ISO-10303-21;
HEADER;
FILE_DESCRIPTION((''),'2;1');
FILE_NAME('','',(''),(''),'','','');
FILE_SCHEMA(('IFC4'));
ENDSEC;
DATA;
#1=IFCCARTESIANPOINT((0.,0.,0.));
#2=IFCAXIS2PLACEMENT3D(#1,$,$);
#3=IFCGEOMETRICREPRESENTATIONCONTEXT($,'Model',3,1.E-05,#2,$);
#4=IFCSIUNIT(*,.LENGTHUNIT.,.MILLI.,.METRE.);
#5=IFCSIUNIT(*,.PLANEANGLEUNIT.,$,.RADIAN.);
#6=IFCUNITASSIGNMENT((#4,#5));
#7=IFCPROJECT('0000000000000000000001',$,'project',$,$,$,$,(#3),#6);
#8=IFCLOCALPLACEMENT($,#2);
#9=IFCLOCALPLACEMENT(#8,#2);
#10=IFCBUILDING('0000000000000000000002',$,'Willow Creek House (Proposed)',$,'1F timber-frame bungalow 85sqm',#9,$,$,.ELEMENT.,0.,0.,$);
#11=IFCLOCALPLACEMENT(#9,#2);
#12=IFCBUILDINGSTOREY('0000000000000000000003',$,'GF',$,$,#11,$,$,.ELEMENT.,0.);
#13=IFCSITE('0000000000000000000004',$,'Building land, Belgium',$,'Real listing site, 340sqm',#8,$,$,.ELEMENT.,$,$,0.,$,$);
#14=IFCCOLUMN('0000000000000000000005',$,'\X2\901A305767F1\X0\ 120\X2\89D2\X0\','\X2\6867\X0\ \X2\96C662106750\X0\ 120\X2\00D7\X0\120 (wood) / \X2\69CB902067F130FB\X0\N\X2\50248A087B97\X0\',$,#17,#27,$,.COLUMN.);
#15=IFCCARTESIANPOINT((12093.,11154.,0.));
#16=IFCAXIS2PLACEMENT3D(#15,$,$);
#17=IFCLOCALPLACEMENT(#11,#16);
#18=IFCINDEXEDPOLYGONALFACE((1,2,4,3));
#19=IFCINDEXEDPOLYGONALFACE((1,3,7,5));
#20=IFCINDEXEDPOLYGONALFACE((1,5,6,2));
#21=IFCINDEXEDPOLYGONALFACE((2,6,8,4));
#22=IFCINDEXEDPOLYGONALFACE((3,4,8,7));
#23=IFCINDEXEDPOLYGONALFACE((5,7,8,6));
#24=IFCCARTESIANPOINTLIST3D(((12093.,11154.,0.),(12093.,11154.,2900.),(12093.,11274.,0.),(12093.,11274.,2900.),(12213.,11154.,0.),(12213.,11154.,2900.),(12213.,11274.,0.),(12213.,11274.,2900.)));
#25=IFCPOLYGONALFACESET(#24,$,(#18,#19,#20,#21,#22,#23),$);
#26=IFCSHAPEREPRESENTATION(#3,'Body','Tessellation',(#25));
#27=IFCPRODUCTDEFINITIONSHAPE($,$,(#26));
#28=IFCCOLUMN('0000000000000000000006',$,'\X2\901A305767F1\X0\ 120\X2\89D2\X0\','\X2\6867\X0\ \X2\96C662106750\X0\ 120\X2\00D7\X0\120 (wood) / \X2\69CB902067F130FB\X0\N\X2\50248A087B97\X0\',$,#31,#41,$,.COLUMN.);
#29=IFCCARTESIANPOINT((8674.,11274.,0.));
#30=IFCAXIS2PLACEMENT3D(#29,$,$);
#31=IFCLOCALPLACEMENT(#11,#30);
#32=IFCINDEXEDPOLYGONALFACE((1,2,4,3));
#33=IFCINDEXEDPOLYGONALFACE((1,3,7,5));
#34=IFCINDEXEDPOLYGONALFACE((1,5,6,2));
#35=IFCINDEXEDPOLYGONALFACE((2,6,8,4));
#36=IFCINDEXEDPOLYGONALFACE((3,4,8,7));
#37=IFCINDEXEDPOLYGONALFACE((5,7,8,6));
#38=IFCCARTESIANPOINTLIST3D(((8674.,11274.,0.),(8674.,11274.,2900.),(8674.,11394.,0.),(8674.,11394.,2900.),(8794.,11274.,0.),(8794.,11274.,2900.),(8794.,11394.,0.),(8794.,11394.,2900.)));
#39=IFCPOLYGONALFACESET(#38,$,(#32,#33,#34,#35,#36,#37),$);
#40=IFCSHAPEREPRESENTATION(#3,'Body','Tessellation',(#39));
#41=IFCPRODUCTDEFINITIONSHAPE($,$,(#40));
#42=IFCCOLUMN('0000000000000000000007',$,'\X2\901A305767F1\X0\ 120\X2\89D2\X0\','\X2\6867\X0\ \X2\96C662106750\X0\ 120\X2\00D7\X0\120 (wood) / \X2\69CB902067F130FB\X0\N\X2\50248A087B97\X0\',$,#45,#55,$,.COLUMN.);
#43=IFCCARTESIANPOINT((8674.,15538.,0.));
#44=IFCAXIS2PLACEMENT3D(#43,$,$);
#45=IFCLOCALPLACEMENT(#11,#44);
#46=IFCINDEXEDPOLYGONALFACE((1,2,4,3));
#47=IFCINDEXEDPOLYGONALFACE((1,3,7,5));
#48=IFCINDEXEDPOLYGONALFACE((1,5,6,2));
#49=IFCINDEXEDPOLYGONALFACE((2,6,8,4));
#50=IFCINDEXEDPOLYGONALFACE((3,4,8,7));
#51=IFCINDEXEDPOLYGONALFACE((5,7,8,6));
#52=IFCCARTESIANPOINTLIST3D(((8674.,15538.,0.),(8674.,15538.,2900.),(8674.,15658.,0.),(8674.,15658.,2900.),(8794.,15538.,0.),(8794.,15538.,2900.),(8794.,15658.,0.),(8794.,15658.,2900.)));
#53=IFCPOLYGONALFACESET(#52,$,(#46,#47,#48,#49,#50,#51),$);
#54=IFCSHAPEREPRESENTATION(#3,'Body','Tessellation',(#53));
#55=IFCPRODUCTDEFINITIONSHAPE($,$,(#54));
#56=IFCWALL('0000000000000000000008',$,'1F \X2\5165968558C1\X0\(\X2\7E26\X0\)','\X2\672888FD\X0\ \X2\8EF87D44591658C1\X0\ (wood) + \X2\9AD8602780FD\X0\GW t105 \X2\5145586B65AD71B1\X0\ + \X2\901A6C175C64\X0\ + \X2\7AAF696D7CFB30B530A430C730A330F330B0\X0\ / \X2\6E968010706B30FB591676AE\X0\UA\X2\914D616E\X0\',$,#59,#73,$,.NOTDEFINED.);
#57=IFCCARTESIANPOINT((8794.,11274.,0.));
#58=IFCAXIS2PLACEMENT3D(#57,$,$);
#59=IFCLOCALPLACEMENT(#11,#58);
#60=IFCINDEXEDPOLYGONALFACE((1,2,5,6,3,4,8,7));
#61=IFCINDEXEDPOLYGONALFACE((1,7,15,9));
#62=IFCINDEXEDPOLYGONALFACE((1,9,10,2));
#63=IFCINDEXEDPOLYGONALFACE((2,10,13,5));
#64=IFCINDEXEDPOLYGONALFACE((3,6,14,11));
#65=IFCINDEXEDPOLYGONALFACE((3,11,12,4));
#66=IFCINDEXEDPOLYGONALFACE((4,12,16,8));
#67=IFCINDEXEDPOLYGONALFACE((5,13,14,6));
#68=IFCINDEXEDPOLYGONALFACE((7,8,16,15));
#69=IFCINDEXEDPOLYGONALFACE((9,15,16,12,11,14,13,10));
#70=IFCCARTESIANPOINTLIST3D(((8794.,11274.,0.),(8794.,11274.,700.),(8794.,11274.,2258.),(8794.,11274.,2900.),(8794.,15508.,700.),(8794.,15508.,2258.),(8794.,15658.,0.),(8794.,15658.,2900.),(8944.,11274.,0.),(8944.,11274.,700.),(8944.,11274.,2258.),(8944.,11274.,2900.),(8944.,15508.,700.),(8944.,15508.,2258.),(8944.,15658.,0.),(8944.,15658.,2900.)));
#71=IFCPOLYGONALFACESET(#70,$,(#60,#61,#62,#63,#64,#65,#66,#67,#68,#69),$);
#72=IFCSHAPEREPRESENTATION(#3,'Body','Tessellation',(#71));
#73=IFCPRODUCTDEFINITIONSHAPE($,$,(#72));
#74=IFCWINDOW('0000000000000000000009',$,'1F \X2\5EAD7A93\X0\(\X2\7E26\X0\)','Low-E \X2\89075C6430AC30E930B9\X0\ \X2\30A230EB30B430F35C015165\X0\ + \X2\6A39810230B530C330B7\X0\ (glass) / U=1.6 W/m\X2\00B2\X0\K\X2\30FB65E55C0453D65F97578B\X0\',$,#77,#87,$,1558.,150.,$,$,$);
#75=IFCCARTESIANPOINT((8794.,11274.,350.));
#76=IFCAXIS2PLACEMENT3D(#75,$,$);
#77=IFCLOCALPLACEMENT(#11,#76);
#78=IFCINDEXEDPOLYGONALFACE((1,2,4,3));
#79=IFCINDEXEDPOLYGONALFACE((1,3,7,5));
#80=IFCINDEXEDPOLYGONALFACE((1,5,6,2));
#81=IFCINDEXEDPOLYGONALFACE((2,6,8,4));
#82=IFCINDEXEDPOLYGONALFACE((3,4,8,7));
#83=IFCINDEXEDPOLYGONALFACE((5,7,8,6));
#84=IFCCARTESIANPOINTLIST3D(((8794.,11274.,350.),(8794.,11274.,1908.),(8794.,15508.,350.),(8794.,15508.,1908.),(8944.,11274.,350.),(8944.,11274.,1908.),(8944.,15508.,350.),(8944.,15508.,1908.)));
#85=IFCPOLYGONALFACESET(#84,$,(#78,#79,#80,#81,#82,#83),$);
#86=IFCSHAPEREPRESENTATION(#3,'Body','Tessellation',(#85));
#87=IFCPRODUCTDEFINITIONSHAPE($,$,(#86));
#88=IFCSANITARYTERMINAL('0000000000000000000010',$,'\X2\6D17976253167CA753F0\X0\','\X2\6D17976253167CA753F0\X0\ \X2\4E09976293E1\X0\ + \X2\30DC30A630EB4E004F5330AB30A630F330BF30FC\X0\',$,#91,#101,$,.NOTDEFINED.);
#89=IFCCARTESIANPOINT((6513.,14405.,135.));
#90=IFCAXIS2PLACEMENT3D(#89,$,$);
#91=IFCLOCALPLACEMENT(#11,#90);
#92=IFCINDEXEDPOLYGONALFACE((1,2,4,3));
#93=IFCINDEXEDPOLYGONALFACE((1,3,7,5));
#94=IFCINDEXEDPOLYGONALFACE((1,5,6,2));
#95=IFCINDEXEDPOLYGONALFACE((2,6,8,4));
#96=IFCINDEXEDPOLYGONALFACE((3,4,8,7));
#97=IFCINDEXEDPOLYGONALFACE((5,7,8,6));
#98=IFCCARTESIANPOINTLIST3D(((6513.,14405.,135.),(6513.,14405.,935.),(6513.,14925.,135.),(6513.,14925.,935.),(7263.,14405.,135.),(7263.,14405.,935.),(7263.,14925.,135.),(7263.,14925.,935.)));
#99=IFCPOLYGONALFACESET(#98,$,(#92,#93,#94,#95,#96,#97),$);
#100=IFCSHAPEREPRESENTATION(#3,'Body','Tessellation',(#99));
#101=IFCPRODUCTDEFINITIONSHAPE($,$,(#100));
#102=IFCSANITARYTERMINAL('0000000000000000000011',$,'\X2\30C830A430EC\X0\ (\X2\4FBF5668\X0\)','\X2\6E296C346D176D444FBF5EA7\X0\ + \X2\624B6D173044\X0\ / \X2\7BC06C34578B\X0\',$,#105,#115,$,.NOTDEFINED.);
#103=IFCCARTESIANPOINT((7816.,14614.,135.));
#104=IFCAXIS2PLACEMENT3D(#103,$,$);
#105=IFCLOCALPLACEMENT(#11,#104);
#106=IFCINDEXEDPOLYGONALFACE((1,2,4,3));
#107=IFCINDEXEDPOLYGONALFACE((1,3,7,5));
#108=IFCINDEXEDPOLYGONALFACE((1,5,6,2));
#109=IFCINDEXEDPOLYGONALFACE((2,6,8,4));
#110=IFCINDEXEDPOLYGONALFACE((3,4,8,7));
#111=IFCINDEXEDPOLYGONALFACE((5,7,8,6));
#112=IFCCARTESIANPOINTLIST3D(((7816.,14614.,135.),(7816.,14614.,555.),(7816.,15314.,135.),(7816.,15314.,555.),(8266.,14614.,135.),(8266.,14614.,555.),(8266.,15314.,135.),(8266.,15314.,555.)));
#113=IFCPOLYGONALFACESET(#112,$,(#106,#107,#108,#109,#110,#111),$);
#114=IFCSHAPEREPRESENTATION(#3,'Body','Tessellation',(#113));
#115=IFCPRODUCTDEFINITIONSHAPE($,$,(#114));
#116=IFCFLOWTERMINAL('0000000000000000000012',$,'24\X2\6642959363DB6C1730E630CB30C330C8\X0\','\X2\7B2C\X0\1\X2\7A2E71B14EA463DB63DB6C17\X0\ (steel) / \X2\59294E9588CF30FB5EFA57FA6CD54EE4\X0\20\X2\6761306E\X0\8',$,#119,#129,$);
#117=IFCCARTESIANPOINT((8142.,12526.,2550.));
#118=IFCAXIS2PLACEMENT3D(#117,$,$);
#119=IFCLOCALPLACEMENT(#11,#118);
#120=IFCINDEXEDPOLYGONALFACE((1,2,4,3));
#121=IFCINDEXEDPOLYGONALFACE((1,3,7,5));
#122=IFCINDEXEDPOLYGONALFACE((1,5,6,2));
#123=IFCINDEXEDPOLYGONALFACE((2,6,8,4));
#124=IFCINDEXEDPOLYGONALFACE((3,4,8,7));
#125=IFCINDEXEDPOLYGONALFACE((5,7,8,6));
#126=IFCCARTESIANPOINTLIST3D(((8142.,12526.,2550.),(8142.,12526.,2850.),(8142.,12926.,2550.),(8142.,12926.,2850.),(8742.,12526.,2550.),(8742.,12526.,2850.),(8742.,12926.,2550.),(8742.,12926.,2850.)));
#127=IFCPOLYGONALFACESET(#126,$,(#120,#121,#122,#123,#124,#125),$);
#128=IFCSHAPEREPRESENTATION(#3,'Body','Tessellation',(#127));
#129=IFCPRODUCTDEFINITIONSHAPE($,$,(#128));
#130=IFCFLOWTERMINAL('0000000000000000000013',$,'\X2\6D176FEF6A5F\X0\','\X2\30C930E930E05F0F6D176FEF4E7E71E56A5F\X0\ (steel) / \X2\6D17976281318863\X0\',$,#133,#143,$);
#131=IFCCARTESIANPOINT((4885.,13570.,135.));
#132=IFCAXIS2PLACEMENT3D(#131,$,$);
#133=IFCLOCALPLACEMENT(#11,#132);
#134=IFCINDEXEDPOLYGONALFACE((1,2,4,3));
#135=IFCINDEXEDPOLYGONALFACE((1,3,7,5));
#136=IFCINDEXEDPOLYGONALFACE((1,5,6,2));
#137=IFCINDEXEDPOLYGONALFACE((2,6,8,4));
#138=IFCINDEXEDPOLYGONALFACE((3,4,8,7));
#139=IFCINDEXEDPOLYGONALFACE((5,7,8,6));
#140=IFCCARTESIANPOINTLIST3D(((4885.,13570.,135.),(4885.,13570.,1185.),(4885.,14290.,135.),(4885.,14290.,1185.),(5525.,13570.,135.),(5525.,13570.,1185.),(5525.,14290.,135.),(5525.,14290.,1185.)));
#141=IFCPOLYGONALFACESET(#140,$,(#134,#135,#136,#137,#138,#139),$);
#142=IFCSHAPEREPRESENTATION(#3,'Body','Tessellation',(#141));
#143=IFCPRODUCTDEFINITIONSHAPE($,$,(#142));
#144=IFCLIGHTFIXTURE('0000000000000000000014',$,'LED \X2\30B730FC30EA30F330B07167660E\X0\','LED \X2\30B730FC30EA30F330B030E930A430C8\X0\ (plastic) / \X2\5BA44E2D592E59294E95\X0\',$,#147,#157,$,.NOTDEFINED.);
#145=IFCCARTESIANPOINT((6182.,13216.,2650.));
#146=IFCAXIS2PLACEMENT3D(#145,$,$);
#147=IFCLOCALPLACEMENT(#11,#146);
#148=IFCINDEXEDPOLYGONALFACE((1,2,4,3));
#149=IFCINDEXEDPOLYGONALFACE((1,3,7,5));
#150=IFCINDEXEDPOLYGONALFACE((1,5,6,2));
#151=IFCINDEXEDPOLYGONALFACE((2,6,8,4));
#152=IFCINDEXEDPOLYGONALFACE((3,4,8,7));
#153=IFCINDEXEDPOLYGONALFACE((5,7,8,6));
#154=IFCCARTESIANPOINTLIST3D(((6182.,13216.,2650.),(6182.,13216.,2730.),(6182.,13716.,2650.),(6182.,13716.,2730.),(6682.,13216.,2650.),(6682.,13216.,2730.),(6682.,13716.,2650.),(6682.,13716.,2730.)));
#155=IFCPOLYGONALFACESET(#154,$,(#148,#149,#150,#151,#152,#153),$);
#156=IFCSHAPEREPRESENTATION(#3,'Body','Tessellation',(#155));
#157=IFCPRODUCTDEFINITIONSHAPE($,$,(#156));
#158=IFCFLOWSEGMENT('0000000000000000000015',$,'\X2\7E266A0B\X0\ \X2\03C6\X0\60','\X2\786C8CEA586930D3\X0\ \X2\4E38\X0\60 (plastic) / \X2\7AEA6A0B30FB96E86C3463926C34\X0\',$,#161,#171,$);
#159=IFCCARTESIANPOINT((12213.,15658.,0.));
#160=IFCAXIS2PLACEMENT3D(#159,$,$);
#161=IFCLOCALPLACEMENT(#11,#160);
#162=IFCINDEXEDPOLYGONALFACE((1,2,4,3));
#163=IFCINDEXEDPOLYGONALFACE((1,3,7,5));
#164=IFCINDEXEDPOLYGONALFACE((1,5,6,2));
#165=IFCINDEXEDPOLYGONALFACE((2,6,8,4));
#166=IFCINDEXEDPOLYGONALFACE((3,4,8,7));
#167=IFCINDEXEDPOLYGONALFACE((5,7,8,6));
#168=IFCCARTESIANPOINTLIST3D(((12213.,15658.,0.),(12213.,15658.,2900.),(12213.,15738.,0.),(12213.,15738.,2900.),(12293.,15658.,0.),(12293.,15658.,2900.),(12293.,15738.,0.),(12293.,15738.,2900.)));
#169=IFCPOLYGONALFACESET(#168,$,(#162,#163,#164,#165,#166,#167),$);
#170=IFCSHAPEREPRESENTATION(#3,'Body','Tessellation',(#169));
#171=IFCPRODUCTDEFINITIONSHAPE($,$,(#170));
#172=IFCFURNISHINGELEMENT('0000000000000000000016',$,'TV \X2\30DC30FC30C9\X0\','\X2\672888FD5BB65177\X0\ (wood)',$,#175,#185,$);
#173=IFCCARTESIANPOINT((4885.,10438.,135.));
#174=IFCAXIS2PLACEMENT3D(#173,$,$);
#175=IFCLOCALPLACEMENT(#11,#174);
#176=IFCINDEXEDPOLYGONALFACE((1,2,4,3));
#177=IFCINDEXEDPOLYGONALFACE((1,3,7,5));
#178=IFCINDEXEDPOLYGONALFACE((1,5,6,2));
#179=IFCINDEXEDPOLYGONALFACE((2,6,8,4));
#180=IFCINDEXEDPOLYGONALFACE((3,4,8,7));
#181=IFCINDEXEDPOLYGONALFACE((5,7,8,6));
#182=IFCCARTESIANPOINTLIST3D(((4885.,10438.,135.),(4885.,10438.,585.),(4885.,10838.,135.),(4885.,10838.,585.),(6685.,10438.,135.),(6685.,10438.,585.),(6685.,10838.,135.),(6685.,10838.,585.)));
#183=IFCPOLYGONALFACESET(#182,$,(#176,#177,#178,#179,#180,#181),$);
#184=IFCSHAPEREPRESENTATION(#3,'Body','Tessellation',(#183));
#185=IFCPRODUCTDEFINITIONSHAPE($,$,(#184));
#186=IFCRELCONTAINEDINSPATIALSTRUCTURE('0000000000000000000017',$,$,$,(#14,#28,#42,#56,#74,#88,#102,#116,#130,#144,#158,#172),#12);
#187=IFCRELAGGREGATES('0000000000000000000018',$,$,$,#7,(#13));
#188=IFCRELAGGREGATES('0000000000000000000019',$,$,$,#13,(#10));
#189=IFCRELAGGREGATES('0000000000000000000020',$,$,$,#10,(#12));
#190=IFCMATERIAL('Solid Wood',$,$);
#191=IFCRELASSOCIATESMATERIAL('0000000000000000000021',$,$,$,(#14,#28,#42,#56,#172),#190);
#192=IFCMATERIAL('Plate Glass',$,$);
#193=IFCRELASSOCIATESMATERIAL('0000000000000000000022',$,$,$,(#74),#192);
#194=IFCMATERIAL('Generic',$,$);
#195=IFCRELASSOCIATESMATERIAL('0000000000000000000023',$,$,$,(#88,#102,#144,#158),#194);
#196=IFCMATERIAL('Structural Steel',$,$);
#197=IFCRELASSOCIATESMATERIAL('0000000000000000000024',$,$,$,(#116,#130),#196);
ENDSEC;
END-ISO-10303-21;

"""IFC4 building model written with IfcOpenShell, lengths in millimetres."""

from ifc_helpers import new_model, si_unit, frame, frame_2d, origin, place, context, project, spatial, rectangle, extrude, material, element, fill, save


model = new_model("IFC4")

# Units and contexts
model_context = context("Model", 3, precision=1e-05, world=origin())
ifc_project = project(units=[si_unit("LENGTHUNIT", "METRE", prefix="MILLI"), si_unit("PLANEANGLEUNIT", "RADIAN")], contexts=[model_context])

# Site, building, storey
site_placement = place(None, origin())
site = spatial("IfcSite", under=ifc_project, at=site_placement, Name="Building land, Belgium", ObjectType="Real listing site, 340sqm", CompositionType="ELEMENT", RefElevation=0.0)
building_placement = place(site_placement, origin())
building = spatial("IfcBuilding", under=site, at=building_placement, Name="Willow Creek House (Proposed)", ObjectType="1F timber-frame bungalow 85sqm", CompositionType="ELEMENT", ElevationOfRefHeight=0.0, ElevationOfTerrain=0.0)
storey_placement = place(building_placement, origin())
storey = spatial("IfcBuildingStorey", under=building, at=storey_placement, Name="GF", CompositionType="ELEMENT", Elevation=0.0)

# Columns
ifc_material_1 = material(Name="Solid Wood")
column_1_placement = place(storey_placement, frame((12093.0, 11154.0, 0.0)))
element("IfcColumn", 1, at=column_1_placement, inside=storey, material=ifc_material_1, Name="通し柱 120角", Description="桧 集成材 120×120 (wood) / 構造柱・N値計算", PredefinedType="COLUMN", context=model_context, shape_type="SweptSolid", body=[
    extrude(rectangle(XDim=120.0, YDim=120.0, at=frame_2d((60.0, 60.0))), frame((12093.0, 11154.0, 0.0)), (0.0, 0.0, 1.0), 2900.0),
])
column_2_placement = place(storey_placement, frame((8674.0, 11274.0, 0.0)))
element("IfcColumn", 2, at=column_2_placement, inside=storey, material=ifc_material_1, Name="通し柱 120角", Description="桧 集成材 120×120 (wood) / 構造柱・N値計算", PredefinedType="COLUMN", context=model_context, shape_type="SweptSolid", body=[
    extrude(rectangle(XDim=120.0, YDim=120.0, at=frame_2d((60.0, 60.0))), frame((8674.0, 11274.0, 0.0)), (0.0, 0.0, 1.0), 2900.0),
])
column_3_placement = place(storey_placement, frame((8674.0, 15538.0, 0.0)))
element("IfcColumn", 3, at=column_3_placement, inside=storey, material=ifc_material_1, Name="通し柱 120角", Description="桧 集成材 120×120 (wood) / 構造柱・N値計算", PredefinedType="COLUMN", context=model_context, shape_type="SweptSolid", body=[
    extrude(rectangle(XDim=120.0, YDim=120.0, at=frame_2d((60.0, 60.0))), frame((8674.0, 15538.0, 0.0)), (0.0, 0.0, 1.0), 2900.0),
])

# Wall, opening, window
wall_1_placement = place(storey_placement, frame((8794.0, 11274.0, 0.0)))
wall_1 = element("IfcWall", 4, at=wall_1_placement, inside=storey, material=ifc_material_1, Name="1F 入隅壁(縦)", Description="木製 軸組外壁 (wood) + 高性能GW t105 充填断熱 + 通気層 + 窯業系サイディング / 準耐火・外皮UA配慮", PredefinedType="NOTDEFINED", context=model_context, shape_type="SweptSolid", body=[
    extrude(rectangle(XDim=150.0, YDim=4384.0, at=frame_2d((75.0, 2192.0))), frame((8794.0, 11274.0, 0.0)), (0.0, 0.0, 1.0), 2900.0),
])
opening_placement = place(storey_placement, frame((8794.0, 11274.0, 350.0)))
opening = element("IfcOpeningElement", 5, at=opening_placement, cuts=wall_1, PredefinedType="NOTDEFINED", context=model_context, shape_type="SweptSolid", body=[
    extrude(rectangle(XDim=150.0, YDim=4234.0, at=frame_2d((75.0, 2117.0))), frame((8794.0, 11274.0, 350.0)), (0.0, 0.0, 1.0), 1558.0),
])
ifc_material_2 = material(Name="Plate Glass")
window_placement = place(storey_placement, frame((8794.0, 11274.0, 350.0)))
window = element("IfcWindow", 6, at=window_placement, inside=storey, material=ifc_material_2, Name="1F 庭窓(縦)", Description="Low-E 複層ガラス アルゴン封入 + 樹脂サッシ (glass) / U=1.6 W/m²K・日射取得型", OverallHeight=1558.0, OverallWidth=150.0, context=model_context, shape_type="SweptSolid", body=[
    extrude(rectangle(XDim=150.0, YDim=4234.0, at=frame_2d((75.0, 2117.0))), frame((8794.0, 11274.0, 350.0)), (0.0, 0.0, 1.0), 1558.0),
])
fill(opening, window)

# Sanitary terminals
ifc_material_3 = material(Name="Generic")
sanitary_terminal_1_placement = place(storey_placement, frame((6513.0, 14405.0, 135.0)))
element("IfcSanitaryTerminal", 7, at=sanitary_terminal_1_placement, inside=storey, material=ifc_material_3, Name="洗面化粧台", Description="洗面化粧台 三面鏡 + ボウル一体カウンター", PredefinedType="NOTDEFINED", context=model_context, shape_type="SweptSolid", body=[
    extrude(rectangle(XDim=750.0, YDim=520.0, at=frame_2d((375.0, 260.0))), frame((6513.0, 14405.0, 135.0)), (0.0, 0.0, 1.0), 800.0),
])
sanitary_terminal_2_placement = place(storey_placement, frame((7816.0, 14614.0, 135.0)))
element("IfcSanitaryTerminal", 8, at=sanitary_terminal_2_placement, inside=storey, material=ifc_material_3, Name="トイレ (便器)", Description="温水洗浄便座 + 手洗い / 節水型", PredefinedType="NOTDEFINED", context=model_context, shape_type="SweptSolid", body=[
    extrude(rectangle(XDim=450.0, YDim=700.0, at=frame_2d((225.0, 350.0))), frame((7816.0, 14614.0, 135.0)), (0.0, 0.0, 1.0), 420.0),
])

# Flow terminals
ifc_material_4 = material(Name="Structural Steel")
flow_terminal_1_placement = place(storey_placement, frame((8142.0, 12526.0, 2550.0)))
element("IfcFlowTerminal", 9, at=flow_terminal_1_placement, inside=storey, material=ifc_material_4, Name="24時間換気ユニット", Description="第1種熱交換換気 (steel) / 天井裏・建基法令20条の8", context=model_context, shape_type="SweptSolid", body=[
    extrude(rectangle(XDim=600.0, YDim=400.0, at=frame_2d((300.0, 200.0))), frame((8142.0, 12526.0, 2550.0)), (0.0, 0.0, 1.0), 300.0),
])
flow_terminal_2_placement = place(storey_placement, frame((4885.0, 13570.0, 135.0)))
element("IfcFlowTerminal", 10, at=flow_terminal_2_placement, inside=storey, material=ifc_material_4, Name="洗濯機", Description="ドラム式洗濯乾燥機 (steel) / 洗面脱衣", context=model_context, shape_type="SweptSolid", body=[
    extrude(rectangle(XDim=640.0, YDim=720.0, at=frame_2d((320.0, 360.0))), frame((4885.0, 13570.0, 135.0)), (0.0, 0.0, 1.0), 1050.0),
])

# Light fixture
light_fixture_placement = place(storey_placement, frame((6182.0, 13216.0, 2650.0)))
element("IfcLightFixture", 11, at=light_fixture_placement, inside=storey, material=ifc_material_3, Name="LED シーリング照明", Description="LED シーリングライト (plastic) / 室中央天井", PredefinedType="NOTDEFINED", context=model_context, shape_type="SweptSolid", body=[
    extrude(rectangle(XDim=500.0, YDim=500.0, at=frame_2d((250.0, 250.0))), frame((6182.0, 13216.0, 2650.0)), (0.0, 0.0, 1.0), 80.0),
])

# Flow segment
flow_segment_placement = place(storey_placement, frame((12213.0, 15658.0, 0.0)))
element("IfcFlowSegment", 12, at=flow_segment_placement, inside=storey, material=ifc_material_3, Name="縦樋 φ60", Description="硬質塩ビ 丸60 (plastic) / 竪樋・雨水排水", context=model_context, shape_type="SweptSolid", body=[
    extrude(rectangle(XDim=80.0, YDim=80.0, at=frame_2d((40.0, 40.0))), frame((12213.0, 15658.0, 0.0)), (0.0, 0.0, 1.0), 2900.0),
])

# Furnishing element
furnishing_placement = place(storey_placement, frame((4885.0, 10438.0, 135.0)))
element("IfcFurnishingElement", 13, at=furnishing_placement, inside=storey, material=ifc_material_1, Name="TV ボード", Description="木製家具 (wood)", context=model_context, shape_type="SweptSolid", body=[
    extrude(rectangle(XDim=1800.0, YDim=400.0, at=frame_2d((900.0, 200.0))), frame((4885.0, 10438.0, 135.0)), (0.0, 0.0, 1.0), 450.0),
])

save(model, "model.ifc")
